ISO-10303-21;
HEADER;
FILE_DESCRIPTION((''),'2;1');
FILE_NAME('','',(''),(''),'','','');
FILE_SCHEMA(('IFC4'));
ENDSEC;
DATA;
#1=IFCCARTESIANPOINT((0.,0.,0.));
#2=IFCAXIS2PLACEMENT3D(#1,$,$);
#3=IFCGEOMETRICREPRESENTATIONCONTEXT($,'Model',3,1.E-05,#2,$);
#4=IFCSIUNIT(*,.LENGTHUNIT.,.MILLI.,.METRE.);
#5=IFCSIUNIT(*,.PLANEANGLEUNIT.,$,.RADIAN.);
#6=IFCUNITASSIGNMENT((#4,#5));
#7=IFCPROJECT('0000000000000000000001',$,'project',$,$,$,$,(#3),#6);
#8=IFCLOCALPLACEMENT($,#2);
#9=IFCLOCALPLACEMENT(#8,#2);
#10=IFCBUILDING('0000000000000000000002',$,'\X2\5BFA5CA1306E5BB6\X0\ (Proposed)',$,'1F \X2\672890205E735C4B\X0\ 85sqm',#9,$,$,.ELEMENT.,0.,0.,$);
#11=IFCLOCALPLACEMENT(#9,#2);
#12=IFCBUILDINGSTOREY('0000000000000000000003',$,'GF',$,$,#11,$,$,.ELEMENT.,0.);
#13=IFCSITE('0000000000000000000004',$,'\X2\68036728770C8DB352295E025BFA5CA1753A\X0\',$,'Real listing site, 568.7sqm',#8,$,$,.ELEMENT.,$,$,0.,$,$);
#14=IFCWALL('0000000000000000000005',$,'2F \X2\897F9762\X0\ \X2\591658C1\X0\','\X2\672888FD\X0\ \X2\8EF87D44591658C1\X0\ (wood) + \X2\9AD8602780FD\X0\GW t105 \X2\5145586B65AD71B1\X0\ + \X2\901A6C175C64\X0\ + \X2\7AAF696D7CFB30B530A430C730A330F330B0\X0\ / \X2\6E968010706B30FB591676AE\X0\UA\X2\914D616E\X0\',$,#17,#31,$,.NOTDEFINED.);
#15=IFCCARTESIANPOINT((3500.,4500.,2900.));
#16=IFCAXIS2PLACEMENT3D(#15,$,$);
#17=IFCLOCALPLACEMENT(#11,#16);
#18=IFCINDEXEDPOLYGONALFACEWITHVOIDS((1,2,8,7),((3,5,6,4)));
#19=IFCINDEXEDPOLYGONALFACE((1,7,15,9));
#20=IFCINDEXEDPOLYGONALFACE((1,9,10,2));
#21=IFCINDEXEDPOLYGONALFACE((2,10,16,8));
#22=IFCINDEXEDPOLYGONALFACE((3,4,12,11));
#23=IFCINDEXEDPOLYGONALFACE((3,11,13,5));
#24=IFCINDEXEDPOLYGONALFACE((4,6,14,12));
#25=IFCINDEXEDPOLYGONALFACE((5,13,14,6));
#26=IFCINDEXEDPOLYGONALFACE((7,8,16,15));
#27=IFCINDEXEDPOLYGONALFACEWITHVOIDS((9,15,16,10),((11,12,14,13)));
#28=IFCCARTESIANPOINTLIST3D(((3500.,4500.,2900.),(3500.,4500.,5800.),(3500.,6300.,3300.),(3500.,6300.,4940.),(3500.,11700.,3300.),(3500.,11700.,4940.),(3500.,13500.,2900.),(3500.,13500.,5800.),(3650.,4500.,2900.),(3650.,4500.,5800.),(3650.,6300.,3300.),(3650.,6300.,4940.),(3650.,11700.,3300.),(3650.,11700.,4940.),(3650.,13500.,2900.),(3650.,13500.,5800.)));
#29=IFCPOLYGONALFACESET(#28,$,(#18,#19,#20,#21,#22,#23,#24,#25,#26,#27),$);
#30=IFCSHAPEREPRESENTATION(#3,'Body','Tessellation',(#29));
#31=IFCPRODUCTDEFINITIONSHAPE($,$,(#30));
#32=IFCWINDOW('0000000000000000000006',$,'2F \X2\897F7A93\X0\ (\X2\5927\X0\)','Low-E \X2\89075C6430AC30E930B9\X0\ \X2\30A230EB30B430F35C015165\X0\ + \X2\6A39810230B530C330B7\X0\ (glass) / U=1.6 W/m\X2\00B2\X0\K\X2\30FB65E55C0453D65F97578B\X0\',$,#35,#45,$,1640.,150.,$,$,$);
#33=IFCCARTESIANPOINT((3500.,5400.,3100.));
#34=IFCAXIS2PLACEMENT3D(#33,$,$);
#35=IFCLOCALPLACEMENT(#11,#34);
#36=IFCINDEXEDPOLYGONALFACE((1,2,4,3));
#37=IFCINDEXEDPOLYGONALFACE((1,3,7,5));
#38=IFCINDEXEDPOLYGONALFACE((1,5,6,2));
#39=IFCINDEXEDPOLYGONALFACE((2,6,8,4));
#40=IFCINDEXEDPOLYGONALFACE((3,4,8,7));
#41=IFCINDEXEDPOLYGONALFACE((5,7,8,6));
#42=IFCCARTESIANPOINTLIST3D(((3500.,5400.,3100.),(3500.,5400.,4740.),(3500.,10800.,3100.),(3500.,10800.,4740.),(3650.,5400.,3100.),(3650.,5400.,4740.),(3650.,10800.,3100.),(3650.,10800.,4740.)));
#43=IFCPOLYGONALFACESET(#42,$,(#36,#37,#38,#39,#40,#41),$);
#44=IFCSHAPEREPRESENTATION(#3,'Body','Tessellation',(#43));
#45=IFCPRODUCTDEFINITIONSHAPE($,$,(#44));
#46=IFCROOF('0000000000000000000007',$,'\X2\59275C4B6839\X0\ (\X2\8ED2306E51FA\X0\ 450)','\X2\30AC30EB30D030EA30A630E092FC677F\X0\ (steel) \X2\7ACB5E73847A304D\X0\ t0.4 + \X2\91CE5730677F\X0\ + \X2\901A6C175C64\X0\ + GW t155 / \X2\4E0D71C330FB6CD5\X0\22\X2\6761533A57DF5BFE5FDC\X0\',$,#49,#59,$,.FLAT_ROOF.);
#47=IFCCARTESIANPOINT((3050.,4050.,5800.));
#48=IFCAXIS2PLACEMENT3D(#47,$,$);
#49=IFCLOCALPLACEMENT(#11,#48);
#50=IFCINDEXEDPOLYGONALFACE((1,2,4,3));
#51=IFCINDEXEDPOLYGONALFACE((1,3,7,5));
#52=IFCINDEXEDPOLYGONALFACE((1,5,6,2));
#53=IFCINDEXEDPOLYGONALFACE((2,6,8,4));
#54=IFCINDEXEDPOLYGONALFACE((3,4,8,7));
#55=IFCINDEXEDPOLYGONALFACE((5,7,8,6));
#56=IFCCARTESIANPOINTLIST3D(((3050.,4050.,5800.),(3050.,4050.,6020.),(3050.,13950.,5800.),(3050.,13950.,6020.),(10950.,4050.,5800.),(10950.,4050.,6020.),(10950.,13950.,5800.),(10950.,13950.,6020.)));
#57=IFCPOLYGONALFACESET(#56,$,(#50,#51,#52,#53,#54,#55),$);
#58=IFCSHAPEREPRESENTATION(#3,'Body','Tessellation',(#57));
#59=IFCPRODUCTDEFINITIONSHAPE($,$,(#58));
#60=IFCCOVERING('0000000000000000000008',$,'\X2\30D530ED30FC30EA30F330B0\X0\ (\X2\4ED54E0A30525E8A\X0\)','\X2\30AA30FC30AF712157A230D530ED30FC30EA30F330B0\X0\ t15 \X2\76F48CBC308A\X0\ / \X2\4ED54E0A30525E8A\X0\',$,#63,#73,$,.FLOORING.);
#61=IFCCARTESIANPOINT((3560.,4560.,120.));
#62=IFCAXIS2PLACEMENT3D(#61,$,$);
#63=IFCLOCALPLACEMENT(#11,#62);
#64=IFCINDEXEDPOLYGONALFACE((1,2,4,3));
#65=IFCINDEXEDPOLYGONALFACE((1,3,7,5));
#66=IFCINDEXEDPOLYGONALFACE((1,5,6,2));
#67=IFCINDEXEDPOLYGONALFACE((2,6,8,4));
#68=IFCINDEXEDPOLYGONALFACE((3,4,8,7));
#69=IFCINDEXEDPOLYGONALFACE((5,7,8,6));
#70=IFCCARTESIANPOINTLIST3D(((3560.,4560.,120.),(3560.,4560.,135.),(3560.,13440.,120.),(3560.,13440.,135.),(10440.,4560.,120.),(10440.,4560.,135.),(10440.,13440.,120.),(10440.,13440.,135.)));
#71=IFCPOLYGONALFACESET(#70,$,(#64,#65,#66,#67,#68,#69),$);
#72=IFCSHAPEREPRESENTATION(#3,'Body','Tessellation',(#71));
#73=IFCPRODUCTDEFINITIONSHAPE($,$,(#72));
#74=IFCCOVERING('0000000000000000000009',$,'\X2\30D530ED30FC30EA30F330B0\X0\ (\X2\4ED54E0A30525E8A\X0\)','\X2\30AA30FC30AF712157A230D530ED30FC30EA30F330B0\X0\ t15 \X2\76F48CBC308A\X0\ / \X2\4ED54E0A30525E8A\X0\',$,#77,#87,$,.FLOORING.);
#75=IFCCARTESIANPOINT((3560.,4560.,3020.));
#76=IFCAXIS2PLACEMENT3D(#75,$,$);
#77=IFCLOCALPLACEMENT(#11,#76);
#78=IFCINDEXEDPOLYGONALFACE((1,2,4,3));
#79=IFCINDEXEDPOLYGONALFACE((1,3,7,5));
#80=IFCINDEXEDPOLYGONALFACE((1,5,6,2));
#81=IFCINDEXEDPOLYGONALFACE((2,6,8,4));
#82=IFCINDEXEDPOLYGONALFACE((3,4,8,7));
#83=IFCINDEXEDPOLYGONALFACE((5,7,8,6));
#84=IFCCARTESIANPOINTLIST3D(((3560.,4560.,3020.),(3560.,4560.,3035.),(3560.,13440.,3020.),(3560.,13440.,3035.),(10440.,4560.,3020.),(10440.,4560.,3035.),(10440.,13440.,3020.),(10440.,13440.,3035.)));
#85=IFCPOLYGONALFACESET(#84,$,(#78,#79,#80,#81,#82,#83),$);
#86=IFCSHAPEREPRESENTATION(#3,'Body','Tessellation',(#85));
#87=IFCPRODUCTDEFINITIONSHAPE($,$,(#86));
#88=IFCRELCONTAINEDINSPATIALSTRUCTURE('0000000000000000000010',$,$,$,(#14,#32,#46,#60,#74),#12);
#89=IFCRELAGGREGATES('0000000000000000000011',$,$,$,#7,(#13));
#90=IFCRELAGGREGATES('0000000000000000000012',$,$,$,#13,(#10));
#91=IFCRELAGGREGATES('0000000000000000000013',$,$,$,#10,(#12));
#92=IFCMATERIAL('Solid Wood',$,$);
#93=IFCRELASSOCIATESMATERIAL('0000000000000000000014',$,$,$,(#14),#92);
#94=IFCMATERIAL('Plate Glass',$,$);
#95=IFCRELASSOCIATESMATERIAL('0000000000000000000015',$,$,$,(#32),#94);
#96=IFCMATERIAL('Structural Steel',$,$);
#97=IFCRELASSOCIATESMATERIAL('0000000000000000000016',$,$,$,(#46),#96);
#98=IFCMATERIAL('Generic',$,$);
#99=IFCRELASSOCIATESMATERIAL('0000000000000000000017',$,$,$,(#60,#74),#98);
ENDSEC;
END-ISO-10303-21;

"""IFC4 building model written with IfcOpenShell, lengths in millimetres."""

from ifc_helpers import new_model, si_unit, frame, frame_2d, origin, place, context, project, spatial, rectangle, extrude, material, element, fill, save


model = new_model("IFC4")

# Units and contexts
model_context = context("Model", 3, precision=1e-05, world=origin())
ifc_project = project(units=[si_unit("LENGTHUNIT", "METRE", prefix="MILLI"), si_unit("PLANEANGLEUNIT", "RADIAN")], contexts=[model_context])

# Site, building, storey
site_placement = place(None, origin())
site = spatial("IfcSite", under=ifc_project, at=site_placement, Name="栃木県足利市寺岡町", ObjectType="Real listing site, 568.7sqm", CompositionType="ELEMENT", RefElevation=0.0)
building_placement = place(site_placement, origin())
building = spatial("IfcBuilding", under=site, at=building_placement, Name="寺岡の家 (Proposed)", ObjectType="1F 木造平屋 85sqm", CompositionType="ELEMENT", ElevationOfRefHeight=0.0, ElevationOfTerrain=0.0)
storey_placement = place(building_placement, origin())
storey = spatial("IfcBuildingStorey", under=building, at=storey_placement, Name="GF", CompositionType="ELEMENT", Elevation=0.0)

# Shared definitions
ifc_material_1 = material(Name="Solid Wood")
ifc_material_2 = material(Name="Generic")

# Shared definitions
ifc_material_3 = material(Name="Plate Glass")

# Wall, opening, window
wall_1_placement = place(storey_placement, frame((3500.0, 4500.0, 2900.0)))
wall_1 = element("IfcWall", 1, at=wall_1_placement, inside=storey, material=ifc_material_1, Name="2F 西面 外壁", Description="木製 軸組外壁 (wood) + 高性能GW t105 充填断熱 + 通気層 + 窯業系サイディング / 準耐火・外皮UA配慮", PredefinedType="NOTDEFINED", context=model_context, shape_type="SweptSolid", body=[
    extrude(rectangle(XDim=150.0, YDim=9000.0, at=frame_2d((75.0, 4500.0))), frame((3500.0, 4500.0, 2900.0)), (0.0, 0.0, 1.0), 2900.0),
])
opening_1_placement = place(storey_placement, frame((3500.0, 5400.0, 3100.0)))
opening_1 = element("IfcOpeningElement", 2, at=opening_1_placement, cuts=wall_1, PredefinedType="NOTDEFINED", context=model_context, shape_type="SweptSolid", body=[
    extrude(rectangle(XDim=150.0, YDim=5400.0, at=frame_2d((75.0, 2700.0))), frame((3500.0, 5400.0, 3100.0)), (0.0, 0.0, 1.0), 1640.0),
])
window_1_placement = place(storey_placement, frame((3500.0, 5400.0, 3100.0)))
window_1 = element("IfcWindow", 3, at=window_1_placement, inside=storey, material=ifc_material_3, Name="2F 西窓 (大)", Description="Low-E 複層ガラス アルゴン封入 + 樹脂サッシ (glass) / U=1.6 W/m²K・日射取得型", OverallHeight=1640.0, OverallWidth=150.0, context=model_context, shape_type="SweptSolid", body=[
    extrude(rectangle(XDim=150.0, YDim=5400.0, at=frame_2d((75.0, 2700.0))), frame((3500.0, 5400.0, 3100.0)), (0.0, 0.0, 1.0), 1640.0),
])
fill(opening_1, window_1)

# Roof
ifc_material_4 = material(Name="Structural Steel")
roof_placement = place(storey_placement, frame((3050.0, 4050.0, 5800.0)))
element("IfcRoof", 4, at=roof_placement, inside=storey, material=ifc_material_4, Name="大屋根 (軒の出 450)", Description="ガルバリウム鋼板 (steel) 立平葺き t0.4 + 野地板 + 通気層 + GW t155 / 不燃・法22条区域対応", PredefinedType="FLAT_ROOF", context=model_context, shape_type="SweptSolid", body=[
    extrude(rectangle(XDim=7900.0, YDim=9900.0, at=frame_2d((3950.0, 4950.0))), frame((3050.0, 4050.0, 5800.0)), (0.0, 0.0, 1.0), 220.0),
])

# Coverings
covering_1_placement = place(storey_placement, frame((3560.0, 4560.0, 120.0)))
element("IfcCovering", 5, at=covering_1_placement, inside=storey, material=ifc_material_2, Name="フローリング (仕上げ床)", Description="オーク無垢フローリング t15 直貼り / 仕上げ床", PredefinedType="FLOORING", context=model_context, shape_type="SweptSolid", body=[
    extrude(rectangle(XDim=6880.0, YDim=8880.0, at=frame_2d((3440.0, 4440.0))), frame((3560.0, 4560.0, 120.0)), (0.0, 0.0, 1.0), 15.0),
])
covering_2_placement = place(storey_placement, frame((3560.0, 4560.0, 3020.0)))
element("IfcCovering", 6, at=covering_2_placement, inside=storey, material=ifc_material_2, Name="フローリング (仕上げ床)", Description="オーク無垢フローリング t15 直貼り / 仕上げ床", PredefinedType="FLOORING", context=model_context, shape_type="SweptSolid", body=[
    extrude(rectangle(XDim=6880.0, YDim=8880.0, at=frame_2d((3440.0, 4440.0))), frame((3560.0, 4560.0, 3020.0)), (0.0, 0.0, 1.0), 15.0),
])

save(model, "model.ifc")
